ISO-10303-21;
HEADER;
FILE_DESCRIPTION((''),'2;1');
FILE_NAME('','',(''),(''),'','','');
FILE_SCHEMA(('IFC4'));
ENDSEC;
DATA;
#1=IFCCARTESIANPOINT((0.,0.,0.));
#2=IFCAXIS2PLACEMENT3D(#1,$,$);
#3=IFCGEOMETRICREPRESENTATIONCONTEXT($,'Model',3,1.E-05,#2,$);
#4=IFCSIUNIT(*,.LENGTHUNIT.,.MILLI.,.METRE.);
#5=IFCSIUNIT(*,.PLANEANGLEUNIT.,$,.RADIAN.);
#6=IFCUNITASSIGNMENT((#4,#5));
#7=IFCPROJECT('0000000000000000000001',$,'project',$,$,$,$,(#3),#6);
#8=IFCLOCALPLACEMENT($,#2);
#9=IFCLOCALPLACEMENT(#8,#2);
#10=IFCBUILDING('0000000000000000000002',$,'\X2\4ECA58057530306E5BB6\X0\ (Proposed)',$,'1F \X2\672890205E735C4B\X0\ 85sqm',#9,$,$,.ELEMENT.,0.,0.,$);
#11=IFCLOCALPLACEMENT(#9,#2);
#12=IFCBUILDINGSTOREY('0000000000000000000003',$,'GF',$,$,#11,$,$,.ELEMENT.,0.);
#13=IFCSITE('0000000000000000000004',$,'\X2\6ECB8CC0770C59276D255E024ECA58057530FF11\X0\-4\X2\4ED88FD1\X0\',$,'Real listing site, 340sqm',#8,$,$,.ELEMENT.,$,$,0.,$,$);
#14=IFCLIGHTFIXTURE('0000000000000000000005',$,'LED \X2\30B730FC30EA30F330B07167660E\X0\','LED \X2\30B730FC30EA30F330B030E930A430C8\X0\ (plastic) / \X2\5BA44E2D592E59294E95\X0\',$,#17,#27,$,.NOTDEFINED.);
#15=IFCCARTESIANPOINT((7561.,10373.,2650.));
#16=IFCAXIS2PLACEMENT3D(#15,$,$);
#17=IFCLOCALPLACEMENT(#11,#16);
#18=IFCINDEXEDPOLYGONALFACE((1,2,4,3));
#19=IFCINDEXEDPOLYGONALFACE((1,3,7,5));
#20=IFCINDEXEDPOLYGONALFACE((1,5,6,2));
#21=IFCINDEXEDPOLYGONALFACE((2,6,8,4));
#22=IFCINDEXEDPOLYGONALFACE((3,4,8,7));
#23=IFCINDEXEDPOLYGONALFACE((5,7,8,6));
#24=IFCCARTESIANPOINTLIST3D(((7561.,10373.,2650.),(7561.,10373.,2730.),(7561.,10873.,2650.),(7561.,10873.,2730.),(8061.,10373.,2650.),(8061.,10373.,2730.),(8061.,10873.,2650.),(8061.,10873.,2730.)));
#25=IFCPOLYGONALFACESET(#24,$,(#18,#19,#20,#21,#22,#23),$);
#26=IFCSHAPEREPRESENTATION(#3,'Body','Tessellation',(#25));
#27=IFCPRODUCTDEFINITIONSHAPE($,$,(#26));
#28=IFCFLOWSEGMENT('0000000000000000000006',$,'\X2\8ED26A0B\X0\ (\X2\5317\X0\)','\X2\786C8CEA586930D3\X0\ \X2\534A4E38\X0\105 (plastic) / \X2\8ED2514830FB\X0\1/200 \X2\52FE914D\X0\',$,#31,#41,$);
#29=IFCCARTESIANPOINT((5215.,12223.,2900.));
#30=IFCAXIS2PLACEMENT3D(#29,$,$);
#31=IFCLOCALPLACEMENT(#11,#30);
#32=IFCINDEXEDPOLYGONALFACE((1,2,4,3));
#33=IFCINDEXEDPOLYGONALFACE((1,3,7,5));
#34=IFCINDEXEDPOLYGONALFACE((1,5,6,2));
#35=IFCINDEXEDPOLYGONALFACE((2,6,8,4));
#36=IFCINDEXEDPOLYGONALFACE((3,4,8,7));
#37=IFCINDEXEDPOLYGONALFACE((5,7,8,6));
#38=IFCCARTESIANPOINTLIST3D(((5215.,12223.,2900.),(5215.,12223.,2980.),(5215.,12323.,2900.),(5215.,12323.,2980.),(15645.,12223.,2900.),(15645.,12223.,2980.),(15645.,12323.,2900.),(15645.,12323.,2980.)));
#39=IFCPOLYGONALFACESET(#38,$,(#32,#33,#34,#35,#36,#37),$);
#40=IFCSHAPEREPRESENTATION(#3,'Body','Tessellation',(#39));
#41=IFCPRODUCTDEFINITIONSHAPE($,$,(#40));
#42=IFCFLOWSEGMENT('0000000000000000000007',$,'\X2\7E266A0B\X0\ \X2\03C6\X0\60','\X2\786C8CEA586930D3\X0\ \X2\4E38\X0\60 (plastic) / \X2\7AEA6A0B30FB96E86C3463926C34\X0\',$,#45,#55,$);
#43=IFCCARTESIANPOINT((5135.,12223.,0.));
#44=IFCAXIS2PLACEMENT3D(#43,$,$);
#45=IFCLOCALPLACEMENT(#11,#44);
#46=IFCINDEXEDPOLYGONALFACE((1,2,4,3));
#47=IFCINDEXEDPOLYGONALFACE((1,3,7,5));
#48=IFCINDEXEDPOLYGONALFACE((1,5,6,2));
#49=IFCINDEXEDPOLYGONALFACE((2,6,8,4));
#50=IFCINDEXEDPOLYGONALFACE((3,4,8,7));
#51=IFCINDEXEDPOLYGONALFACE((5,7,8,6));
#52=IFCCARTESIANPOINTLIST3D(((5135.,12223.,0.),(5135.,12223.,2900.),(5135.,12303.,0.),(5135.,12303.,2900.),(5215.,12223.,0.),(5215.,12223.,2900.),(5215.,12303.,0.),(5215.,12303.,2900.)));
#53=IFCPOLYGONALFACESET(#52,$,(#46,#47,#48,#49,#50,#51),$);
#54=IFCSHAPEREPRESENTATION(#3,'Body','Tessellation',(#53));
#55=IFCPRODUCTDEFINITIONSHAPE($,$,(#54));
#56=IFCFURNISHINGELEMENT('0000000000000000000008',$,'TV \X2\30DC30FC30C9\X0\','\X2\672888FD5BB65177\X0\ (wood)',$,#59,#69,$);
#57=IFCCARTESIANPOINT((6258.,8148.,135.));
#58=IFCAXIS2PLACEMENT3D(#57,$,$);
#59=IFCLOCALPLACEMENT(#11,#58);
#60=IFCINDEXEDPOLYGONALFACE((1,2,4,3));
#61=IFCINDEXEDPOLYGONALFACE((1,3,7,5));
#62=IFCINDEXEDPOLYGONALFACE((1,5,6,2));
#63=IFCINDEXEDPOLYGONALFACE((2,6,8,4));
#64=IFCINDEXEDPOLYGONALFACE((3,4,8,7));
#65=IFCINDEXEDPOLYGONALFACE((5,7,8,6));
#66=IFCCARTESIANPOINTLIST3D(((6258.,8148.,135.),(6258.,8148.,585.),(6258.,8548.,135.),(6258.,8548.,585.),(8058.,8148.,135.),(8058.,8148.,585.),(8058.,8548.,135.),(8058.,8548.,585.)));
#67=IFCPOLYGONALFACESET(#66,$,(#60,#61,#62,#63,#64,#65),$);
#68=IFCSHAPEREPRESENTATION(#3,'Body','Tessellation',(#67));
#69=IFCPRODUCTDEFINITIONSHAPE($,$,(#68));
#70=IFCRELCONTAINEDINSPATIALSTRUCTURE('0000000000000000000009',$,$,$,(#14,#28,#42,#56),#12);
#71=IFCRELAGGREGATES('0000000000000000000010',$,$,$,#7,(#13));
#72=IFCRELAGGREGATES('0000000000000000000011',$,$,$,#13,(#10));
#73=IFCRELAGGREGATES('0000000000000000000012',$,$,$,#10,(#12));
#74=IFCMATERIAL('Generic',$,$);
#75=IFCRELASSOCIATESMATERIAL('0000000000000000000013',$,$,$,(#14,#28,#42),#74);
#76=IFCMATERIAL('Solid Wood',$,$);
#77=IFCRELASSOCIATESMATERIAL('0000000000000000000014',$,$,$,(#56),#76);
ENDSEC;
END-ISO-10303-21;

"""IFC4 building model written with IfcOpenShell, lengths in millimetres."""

from ifc_helpers import new_model, si_unit, frame, frame_2d, origin, place, context, project, spatial, rectangle, extrude, material, element, save


model = new_model("IFC4")

# Units and contexts
model_context = context("Model", 3, precision=1e-05, world=origin())
ifc_project = project(units=[si_unit("LENGTHUNIT", "METRE", prefix="MILLI"), si_unit("PLANEANGLEUNIT", "RADIAN")], contexts=[model_context])

# Site, building, storey
site_placement = place(None, origin())
site = spatial("IfcSite", under=ifc_project, at=site_placement, Name="滋賀県大津市今堅田１-4付近", ObjectType="Real listing site, 340sqm", CompositionType="ELEMENT", RefElevation=0.0)
building_placement = place(site_placement, origin())
building = spatial("IfcBuilding", under=site, at=building_placement, Name="今堅田の家 (Proposed)", ObjectType="1F 木造平屋 85sqm", CompositionType="ELEMENT", ElevationOfRefHeight=0.0, ElevationOfTerrain=0.0)
storey_placement = place(building_placement, origin())
storey = spatial("IfcBuildingStorey", under=building, at=storey_placement, Name="GF", CompositionType="ELEMENT", Elevation=0.0)

# Shared definitions
ifc_material_1 = material(Name="Solid Wood")

# Shared definitions
ifc_material_2 = material(Name="Generic")

# Light fixture
light_fixture_placement = place(storey_placement, frame((7561.0, 10373.0, 2650.0)))
element("IfcLightFixture", 1, at=light_fixture_placement, inside=storey, material=ifc_material_2, Name="LED シーリング照明", Description="LED シーリングライト (plastic) / 室中央天井", PredefinedType="NOTDEFINED", context=model_context, shape_type="SweptSolid", body=[
    extrude(rectangle(XDim=500.0, YDim=500.0, at=frame_2d((250.0, 250.0))), frame((7561.0, 10373.0, 2650.0)), (0.0, 0.0, 1.0), 80.0),
])

# Flow segments
flow_segment_1_placement = place(storey_placement, frame((5215.0, 12223.0, 2900.0)))
element("IfcFlowSegment", 2, at=flow_segment_1_placement, inside=storey, material=ifc_material_2, Name="軒樋 (北)", Description="硬質塩ビ 半丸105 (plastic) / 軒先・1/200 勾配", context=model_context, shape_type="SweptSolid", body=[
    extrude(rectangle(XDim=10430.0, YDim=100.0, at=frame_2d((5215.0, 50.0))), frame((5215.0, 12223.0, 2900.0)), (0.0, 0.0, 1.0), 80.0),
])
flow_segment_2_placement = place(storey_placement, frame((5135.0, 12223.0, 0.0)))
element("IfcFlowSegment", 3, at=flow_segment_2_placement, inside=storey, material=ifc_material_2, Name="縦樋 φ60", Description="硬質塩ビ 丸60 (plastic) / 竪樋・雨水排水", context=model_context, shape_type="SweptSolid", body=[
    extrude(rectangle(XDim=80.0, YDim=80.0, at=frame_2d((40.0, 40.0))), frame((5135.0, 12223.0, 0.0)), (0.0, 0.0, 1.0), 2900.0),
])

# Furnishing element
furnishing_placement = place(storey_placement, frame((6258.0, 8148.0, 135.0)))
element("IfcFurnishingElement", 4, at=furnishing_placement, inside=storey, material=ifc_material_1, Name="TV ボード", Description="木製家具 (wood)", context=model_context, shape_type="SweptSolid", body=[
    extrude(rectangle(XDim=1800.0, YDim=400.0, at=frame_2d((900.0, 200.0))), frame((6258.0, 8148.0, 135.0)), (0.0, 0.0, 1.0), 450.0),
])

save(model, "model.ifc")
